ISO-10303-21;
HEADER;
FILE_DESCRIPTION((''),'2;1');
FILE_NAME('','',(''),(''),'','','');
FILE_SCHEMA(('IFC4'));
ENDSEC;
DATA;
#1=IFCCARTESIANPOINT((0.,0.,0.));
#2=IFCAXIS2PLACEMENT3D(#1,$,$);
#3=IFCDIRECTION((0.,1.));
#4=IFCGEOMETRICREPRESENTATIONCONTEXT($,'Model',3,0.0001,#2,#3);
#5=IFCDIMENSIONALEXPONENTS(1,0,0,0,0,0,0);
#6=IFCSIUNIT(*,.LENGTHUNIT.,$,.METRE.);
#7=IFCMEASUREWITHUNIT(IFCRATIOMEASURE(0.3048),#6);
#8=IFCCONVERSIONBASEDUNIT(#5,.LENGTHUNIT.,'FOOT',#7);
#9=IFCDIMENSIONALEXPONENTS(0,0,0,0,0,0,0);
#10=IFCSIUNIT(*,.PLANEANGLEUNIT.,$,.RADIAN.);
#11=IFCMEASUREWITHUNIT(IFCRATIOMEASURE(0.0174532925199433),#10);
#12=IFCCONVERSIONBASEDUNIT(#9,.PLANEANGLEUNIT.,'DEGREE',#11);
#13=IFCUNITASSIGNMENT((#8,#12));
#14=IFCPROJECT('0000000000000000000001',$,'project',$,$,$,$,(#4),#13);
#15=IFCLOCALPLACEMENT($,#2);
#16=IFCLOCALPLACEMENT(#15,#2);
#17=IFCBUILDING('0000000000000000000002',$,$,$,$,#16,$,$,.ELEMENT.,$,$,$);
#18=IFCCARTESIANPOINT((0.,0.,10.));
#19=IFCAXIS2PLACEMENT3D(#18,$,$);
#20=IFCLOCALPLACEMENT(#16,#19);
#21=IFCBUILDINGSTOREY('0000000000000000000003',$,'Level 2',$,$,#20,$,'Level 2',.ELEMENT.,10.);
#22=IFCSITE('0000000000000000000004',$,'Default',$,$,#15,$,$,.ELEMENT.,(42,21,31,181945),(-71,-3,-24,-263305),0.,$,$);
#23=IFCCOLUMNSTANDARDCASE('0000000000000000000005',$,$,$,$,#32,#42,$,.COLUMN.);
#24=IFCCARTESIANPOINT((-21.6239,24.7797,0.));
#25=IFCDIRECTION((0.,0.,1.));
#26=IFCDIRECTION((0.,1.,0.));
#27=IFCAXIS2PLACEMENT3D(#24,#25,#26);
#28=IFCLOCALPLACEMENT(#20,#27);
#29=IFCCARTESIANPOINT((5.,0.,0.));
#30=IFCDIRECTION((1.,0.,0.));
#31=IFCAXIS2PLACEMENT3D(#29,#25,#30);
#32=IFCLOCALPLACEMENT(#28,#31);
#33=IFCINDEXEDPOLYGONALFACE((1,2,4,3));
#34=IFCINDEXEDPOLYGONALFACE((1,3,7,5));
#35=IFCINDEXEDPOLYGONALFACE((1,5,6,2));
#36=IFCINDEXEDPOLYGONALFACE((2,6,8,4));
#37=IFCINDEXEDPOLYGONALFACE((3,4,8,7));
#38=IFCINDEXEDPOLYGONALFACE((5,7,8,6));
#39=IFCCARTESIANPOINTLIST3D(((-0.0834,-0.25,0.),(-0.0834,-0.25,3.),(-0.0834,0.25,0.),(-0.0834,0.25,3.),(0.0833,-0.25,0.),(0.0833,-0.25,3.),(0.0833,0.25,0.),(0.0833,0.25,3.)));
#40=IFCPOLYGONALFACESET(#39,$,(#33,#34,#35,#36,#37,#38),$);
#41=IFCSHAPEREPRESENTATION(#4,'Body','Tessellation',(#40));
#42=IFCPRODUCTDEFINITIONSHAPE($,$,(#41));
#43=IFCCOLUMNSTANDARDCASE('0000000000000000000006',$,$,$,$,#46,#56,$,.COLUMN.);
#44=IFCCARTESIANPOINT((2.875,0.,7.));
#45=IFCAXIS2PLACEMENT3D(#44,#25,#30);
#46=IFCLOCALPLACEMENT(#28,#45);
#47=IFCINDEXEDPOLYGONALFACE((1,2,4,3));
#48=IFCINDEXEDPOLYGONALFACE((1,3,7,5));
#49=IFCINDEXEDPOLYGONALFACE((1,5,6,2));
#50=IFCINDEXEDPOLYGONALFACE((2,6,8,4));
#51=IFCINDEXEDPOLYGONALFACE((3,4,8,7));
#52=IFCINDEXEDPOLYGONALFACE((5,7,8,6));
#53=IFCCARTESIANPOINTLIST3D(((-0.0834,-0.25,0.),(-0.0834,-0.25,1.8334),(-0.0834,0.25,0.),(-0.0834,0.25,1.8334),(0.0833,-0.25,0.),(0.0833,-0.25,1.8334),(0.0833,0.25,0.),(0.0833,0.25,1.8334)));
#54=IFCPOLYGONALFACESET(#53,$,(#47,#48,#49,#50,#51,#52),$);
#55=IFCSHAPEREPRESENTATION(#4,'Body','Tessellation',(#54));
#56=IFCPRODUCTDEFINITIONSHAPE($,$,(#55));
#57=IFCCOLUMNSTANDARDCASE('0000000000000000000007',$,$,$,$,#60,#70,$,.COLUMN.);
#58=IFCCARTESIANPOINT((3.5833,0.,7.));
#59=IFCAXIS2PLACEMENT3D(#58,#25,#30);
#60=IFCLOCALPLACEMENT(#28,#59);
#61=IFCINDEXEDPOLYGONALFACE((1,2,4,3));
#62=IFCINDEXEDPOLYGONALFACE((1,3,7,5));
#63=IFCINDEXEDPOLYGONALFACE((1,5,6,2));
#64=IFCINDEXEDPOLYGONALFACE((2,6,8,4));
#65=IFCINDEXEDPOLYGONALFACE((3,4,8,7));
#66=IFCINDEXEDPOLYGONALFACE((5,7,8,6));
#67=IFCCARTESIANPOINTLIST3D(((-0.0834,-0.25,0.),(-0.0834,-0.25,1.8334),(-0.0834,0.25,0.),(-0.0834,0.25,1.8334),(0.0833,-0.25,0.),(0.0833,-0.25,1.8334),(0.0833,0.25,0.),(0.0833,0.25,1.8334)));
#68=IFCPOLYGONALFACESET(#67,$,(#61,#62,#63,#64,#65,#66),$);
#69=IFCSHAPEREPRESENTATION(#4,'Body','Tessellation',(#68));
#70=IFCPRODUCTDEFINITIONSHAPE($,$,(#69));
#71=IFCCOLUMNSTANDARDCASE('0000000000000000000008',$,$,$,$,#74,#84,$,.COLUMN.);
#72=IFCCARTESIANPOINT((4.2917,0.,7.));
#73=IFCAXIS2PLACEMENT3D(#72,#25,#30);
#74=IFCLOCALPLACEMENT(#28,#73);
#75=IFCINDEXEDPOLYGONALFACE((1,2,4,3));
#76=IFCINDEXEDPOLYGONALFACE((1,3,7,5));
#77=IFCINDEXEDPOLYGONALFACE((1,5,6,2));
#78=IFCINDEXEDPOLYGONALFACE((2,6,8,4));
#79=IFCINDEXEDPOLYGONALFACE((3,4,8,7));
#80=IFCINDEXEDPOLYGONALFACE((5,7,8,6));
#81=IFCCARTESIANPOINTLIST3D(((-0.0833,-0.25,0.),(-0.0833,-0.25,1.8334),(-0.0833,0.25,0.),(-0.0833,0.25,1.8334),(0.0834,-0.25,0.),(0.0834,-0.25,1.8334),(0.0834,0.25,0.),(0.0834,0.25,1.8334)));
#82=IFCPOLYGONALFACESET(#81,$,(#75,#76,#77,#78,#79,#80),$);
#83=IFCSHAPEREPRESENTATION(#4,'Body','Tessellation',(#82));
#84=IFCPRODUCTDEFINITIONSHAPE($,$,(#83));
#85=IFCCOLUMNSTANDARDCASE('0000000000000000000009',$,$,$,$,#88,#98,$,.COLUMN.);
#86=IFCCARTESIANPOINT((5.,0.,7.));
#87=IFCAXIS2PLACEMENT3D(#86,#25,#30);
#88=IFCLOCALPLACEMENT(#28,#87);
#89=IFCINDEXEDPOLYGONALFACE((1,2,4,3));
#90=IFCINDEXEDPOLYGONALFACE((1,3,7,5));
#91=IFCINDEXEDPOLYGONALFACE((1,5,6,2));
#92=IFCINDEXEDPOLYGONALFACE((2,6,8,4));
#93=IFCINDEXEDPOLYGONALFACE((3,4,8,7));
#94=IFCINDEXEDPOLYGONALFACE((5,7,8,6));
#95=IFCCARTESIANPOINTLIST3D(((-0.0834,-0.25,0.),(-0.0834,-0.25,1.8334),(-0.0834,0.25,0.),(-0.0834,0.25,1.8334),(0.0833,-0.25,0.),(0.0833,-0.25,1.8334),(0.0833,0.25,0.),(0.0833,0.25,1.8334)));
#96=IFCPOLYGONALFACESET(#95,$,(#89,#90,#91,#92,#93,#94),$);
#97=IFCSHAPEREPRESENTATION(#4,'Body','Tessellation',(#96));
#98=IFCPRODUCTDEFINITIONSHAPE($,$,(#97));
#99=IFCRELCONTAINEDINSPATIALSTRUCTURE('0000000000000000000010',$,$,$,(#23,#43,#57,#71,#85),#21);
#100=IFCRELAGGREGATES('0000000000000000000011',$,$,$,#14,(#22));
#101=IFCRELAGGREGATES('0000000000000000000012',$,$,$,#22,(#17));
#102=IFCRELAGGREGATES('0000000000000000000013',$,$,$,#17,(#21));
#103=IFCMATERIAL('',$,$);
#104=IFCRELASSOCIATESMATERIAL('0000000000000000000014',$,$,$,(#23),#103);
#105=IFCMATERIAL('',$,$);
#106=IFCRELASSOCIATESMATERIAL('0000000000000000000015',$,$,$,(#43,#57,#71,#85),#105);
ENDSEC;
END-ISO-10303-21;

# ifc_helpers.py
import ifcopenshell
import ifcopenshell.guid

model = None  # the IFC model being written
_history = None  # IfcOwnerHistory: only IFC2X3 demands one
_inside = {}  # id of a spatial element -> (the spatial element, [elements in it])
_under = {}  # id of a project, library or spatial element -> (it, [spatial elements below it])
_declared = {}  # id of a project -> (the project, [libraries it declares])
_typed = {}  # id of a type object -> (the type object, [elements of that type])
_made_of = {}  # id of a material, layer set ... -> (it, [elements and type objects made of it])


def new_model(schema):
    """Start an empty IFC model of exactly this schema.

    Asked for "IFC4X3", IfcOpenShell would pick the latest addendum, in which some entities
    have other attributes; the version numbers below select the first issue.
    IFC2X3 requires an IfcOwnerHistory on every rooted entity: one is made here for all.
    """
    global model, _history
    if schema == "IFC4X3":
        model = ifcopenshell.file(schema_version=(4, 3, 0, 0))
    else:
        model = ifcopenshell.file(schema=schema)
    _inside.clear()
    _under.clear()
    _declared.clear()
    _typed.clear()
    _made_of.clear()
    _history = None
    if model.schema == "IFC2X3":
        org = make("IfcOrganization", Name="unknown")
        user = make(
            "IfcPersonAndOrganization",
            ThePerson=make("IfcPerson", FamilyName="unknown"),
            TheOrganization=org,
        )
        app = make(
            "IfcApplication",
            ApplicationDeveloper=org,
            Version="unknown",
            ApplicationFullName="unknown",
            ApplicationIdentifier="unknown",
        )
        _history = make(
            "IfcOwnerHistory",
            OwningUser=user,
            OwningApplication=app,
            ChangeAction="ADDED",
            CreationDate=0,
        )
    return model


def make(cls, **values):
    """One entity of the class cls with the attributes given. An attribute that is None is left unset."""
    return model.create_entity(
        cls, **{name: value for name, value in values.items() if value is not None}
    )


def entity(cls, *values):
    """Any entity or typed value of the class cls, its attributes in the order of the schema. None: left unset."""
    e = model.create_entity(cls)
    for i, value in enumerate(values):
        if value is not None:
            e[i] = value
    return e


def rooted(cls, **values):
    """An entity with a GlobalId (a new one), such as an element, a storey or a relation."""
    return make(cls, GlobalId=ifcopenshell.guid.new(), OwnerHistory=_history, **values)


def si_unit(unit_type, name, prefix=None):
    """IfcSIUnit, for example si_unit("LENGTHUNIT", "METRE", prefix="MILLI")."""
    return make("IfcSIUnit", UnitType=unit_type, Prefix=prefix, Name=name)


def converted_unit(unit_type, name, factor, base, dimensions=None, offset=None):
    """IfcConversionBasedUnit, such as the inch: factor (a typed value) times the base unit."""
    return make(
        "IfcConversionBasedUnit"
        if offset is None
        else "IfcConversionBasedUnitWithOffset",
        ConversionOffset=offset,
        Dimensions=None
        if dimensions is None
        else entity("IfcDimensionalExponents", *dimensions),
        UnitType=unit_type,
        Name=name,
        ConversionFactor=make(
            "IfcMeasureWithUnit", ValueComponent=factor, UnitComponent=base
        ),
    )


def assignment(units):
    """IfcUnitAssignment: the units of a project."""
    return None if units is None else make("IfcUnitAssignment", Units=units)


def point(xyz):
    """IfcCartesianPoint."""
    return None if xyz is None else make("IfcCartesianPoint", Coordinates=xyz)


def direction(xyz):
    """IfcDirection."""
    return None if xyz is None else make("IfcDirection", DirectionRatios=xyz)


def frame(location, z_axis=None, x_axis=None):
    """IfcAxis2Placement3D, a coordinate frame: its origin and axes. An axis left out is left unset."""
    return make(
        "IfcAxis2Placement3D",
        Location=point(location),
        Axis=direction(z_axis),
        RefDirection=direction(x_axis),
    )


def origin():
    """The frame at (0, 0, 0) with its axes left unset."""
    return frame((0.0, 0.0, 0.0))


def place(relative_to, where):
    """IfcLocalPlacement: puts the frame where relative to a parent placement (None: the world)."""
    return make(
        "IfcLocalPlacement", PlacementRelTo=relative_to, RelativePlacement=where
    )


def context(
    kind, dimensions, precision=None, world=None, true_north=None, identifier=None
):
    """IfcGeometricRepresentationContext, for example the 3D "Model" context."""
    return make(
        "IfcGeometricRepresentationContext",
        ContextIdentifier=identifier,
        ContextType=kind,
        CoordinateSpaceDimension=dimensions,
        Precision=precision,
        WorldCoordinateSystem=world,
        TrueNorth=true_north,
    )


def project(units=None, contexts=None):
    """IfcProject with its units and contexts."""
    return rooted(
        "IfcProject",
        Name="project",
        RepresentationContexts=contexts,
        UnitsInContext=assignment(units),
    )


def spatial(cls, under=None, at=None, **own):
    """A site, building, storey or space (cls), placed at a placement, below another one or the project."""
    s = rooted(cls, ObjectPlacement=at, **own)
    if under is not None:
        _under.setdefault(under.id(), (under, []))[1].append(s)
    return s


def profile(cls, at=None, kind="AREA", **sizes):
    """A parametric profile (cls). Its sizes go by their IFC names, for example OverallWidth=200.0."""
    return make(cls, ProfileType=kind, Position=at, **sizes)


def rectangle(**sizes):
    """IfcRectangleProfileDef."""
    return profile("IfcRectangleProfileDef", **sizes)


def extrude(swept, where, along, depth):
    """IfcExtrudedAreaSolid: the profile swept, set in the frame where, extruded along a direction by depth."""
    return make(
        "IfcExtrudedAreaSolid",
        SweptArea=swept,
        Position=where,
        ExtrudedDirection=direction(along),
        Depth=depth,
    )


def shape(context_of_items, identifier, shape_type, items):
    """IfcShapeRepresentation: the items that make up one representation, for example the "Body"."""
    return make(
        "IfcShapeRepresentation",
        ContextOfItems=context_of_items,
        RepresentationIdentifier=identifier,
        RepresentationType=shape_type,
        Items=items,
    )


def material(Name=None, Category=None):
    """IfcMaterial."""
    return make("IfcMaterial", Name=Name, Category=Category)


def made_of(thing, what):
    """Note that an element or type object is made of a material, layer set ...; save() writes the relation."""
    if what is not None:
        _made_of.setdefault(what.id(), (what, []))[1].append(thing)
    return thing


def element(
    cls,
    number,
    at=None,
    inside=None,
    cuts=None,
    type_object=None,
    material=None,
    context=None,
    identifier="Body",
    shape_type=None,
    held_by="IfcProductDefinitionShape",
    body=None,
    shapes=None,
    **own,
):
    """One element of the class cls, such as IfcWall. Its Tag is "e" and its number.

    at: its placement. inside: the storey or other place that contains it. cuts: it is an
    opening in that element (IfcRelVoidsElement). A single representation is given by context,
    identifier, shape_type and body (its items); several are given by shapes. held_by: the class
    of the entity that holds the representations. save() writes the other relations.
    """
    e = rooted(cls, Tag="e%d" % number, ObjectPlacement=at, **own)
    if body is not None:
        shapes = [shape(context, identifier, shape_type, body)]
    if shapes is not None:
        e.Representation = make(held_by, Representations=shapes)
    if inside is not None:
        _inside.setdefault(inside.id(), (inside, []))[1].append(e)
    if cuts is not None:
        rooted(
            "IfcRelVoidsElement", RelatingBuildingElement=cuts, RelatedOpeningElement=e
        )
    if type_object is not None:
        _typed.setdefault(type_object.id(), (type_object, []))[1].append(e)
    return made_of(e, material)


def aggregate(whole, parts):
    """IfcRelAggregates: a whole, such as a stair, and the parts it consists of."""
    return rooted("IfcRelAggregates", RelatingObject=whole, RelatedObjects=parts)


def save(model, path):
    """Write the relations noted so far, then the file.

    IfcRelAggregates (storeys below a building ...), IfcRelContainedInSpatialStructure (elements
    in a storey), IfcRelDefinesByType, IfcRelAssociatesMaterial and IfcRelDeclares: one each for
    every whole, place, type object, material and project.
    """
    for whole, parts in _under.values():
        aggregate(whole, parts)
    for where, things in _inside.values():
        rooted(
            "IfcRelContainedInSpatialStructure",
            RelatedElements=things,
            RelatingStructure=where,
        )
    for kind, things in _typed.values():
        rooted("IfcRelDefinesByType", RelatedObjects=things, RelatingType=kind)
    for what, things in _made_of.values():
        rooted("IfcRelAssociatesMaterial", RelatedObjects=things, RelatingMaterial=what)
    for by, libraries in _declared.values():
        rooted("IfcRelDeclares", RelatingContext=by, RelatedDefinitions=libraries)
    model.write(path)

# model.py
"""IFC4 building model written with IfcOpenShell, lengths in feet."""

from ifc_helpers import new_model, entity, si_unit, converted_unit, direction, frame, origin, place, context, project, spatial, rectangle, extrude, material, element, save


model = new_model("IFC4")

# Units and contexts
model_context = context("Model", 3, precision=0.0001, world=origin(), true_north=direction((0.0, 1.0)))
ifc_project = project(units=[converted_unit("LENGTHUNIT", "FOOT", entity("IfcRatioMeasure", 0.3048), si_unit("LENGTHUNIT", "METRE"), dimensions=[1, 0, 0, 0, 0, 0, 0]), converted_unit("PLANEANGLEUNIT", "DEGREE", entity("IfcRatioMeasure", 0.0174532925199433), si_unit("PLANEANGLEUNIT", "RADIAN"), dimensions=[0, 0, 0, 0, 0, 0, 0])], contexts=[model_context])

# Site, building, storey
site_placement = place(None, origin())
site = spatial("IfcSite", under=ifc_project, at=site_placement, Name="Default", CompositionType="ELEMENT", RefLatitude=(42, 21, 31, 181945), RefLongitude=(-71, -3, -24, -263305), RefElevation=0.0)
building_placement = place(site_placement, origin())
building = spatial("IfcBuilding", under=site, at=building_placement, CompositionType="ELEMENT")
storey_placement = place(building_placement, frame((0.0, 0.0, 10.0)))
storey = spatial("IfcBuildingStorey", under=building, at=storey_placement, Name="Level 2", LongName="Level 2", CompositionType="ELEMENT", Elevation=10.0)

# Columns
ifc_material_1 = material(Name="")
placement_1 = place(storey_placement, frame((-21.6239, 24.7797, 0.0), z_axis=(0.0, 0.0, 1.0), x_axis=(0.0, 1.0, 0.0)))
ifc_material_2 = material(Name="")
for number, where, z_axis, x_axis in (
    (1, (5.0, 0.0, 0.0), (0.0, 0.0, 1.0), (1.0, 0.0, 0.0)),
):
    element("IfcColumnStandardCase", number, at=place(placement_1, frame(where, z_axis=z_axis, x_axis=x_axis)), inside=storey, material=ifc_material_2, PredefinedType="COLUMN", context=model_context, shape_type="SweptSolid", body=[
        extrude(rectangle(XDim=0.1667, YDim=0.5), origin(), (0.0, 0.0, 1.0), 3.0),
    ])
for number, where, z_axis, x_axis in (
    (2, (2.875, 0.0, 7.0), (0.0, 0.0, 1.0), (1.0, 0.0, 0.0)),
    (3, (3.5833, 0.0, 7.0), (0.0, 0.0, 1.0), (1.0, 0.0, 0.0)),
    (4, (4.2917, 0.0, 7.0), (0.0, 0.0, 1.0), (1.0, 0.0, 0.0)),
    (5, (5.0, 0.0, 7.0), (0.0, 0.0, 1.0), (1.0, 0.0, 0.0)),
):
    element("IfcColumnStandardCase", number, at=place(placement_1, frame(where, z_axis=z_axis, x_axis=x_axis)), inside=storey, material=ifc_material_1, PredefinedType="COLUMN", context=model_context, shape_type="SweptSolid", body=[
        extrude(rectangle(XDim=0.1667, YDim=0.5), origin(), (0.0, 0.0, 1.0), 1.8334),
    ])

save(model, "model.ifc")
